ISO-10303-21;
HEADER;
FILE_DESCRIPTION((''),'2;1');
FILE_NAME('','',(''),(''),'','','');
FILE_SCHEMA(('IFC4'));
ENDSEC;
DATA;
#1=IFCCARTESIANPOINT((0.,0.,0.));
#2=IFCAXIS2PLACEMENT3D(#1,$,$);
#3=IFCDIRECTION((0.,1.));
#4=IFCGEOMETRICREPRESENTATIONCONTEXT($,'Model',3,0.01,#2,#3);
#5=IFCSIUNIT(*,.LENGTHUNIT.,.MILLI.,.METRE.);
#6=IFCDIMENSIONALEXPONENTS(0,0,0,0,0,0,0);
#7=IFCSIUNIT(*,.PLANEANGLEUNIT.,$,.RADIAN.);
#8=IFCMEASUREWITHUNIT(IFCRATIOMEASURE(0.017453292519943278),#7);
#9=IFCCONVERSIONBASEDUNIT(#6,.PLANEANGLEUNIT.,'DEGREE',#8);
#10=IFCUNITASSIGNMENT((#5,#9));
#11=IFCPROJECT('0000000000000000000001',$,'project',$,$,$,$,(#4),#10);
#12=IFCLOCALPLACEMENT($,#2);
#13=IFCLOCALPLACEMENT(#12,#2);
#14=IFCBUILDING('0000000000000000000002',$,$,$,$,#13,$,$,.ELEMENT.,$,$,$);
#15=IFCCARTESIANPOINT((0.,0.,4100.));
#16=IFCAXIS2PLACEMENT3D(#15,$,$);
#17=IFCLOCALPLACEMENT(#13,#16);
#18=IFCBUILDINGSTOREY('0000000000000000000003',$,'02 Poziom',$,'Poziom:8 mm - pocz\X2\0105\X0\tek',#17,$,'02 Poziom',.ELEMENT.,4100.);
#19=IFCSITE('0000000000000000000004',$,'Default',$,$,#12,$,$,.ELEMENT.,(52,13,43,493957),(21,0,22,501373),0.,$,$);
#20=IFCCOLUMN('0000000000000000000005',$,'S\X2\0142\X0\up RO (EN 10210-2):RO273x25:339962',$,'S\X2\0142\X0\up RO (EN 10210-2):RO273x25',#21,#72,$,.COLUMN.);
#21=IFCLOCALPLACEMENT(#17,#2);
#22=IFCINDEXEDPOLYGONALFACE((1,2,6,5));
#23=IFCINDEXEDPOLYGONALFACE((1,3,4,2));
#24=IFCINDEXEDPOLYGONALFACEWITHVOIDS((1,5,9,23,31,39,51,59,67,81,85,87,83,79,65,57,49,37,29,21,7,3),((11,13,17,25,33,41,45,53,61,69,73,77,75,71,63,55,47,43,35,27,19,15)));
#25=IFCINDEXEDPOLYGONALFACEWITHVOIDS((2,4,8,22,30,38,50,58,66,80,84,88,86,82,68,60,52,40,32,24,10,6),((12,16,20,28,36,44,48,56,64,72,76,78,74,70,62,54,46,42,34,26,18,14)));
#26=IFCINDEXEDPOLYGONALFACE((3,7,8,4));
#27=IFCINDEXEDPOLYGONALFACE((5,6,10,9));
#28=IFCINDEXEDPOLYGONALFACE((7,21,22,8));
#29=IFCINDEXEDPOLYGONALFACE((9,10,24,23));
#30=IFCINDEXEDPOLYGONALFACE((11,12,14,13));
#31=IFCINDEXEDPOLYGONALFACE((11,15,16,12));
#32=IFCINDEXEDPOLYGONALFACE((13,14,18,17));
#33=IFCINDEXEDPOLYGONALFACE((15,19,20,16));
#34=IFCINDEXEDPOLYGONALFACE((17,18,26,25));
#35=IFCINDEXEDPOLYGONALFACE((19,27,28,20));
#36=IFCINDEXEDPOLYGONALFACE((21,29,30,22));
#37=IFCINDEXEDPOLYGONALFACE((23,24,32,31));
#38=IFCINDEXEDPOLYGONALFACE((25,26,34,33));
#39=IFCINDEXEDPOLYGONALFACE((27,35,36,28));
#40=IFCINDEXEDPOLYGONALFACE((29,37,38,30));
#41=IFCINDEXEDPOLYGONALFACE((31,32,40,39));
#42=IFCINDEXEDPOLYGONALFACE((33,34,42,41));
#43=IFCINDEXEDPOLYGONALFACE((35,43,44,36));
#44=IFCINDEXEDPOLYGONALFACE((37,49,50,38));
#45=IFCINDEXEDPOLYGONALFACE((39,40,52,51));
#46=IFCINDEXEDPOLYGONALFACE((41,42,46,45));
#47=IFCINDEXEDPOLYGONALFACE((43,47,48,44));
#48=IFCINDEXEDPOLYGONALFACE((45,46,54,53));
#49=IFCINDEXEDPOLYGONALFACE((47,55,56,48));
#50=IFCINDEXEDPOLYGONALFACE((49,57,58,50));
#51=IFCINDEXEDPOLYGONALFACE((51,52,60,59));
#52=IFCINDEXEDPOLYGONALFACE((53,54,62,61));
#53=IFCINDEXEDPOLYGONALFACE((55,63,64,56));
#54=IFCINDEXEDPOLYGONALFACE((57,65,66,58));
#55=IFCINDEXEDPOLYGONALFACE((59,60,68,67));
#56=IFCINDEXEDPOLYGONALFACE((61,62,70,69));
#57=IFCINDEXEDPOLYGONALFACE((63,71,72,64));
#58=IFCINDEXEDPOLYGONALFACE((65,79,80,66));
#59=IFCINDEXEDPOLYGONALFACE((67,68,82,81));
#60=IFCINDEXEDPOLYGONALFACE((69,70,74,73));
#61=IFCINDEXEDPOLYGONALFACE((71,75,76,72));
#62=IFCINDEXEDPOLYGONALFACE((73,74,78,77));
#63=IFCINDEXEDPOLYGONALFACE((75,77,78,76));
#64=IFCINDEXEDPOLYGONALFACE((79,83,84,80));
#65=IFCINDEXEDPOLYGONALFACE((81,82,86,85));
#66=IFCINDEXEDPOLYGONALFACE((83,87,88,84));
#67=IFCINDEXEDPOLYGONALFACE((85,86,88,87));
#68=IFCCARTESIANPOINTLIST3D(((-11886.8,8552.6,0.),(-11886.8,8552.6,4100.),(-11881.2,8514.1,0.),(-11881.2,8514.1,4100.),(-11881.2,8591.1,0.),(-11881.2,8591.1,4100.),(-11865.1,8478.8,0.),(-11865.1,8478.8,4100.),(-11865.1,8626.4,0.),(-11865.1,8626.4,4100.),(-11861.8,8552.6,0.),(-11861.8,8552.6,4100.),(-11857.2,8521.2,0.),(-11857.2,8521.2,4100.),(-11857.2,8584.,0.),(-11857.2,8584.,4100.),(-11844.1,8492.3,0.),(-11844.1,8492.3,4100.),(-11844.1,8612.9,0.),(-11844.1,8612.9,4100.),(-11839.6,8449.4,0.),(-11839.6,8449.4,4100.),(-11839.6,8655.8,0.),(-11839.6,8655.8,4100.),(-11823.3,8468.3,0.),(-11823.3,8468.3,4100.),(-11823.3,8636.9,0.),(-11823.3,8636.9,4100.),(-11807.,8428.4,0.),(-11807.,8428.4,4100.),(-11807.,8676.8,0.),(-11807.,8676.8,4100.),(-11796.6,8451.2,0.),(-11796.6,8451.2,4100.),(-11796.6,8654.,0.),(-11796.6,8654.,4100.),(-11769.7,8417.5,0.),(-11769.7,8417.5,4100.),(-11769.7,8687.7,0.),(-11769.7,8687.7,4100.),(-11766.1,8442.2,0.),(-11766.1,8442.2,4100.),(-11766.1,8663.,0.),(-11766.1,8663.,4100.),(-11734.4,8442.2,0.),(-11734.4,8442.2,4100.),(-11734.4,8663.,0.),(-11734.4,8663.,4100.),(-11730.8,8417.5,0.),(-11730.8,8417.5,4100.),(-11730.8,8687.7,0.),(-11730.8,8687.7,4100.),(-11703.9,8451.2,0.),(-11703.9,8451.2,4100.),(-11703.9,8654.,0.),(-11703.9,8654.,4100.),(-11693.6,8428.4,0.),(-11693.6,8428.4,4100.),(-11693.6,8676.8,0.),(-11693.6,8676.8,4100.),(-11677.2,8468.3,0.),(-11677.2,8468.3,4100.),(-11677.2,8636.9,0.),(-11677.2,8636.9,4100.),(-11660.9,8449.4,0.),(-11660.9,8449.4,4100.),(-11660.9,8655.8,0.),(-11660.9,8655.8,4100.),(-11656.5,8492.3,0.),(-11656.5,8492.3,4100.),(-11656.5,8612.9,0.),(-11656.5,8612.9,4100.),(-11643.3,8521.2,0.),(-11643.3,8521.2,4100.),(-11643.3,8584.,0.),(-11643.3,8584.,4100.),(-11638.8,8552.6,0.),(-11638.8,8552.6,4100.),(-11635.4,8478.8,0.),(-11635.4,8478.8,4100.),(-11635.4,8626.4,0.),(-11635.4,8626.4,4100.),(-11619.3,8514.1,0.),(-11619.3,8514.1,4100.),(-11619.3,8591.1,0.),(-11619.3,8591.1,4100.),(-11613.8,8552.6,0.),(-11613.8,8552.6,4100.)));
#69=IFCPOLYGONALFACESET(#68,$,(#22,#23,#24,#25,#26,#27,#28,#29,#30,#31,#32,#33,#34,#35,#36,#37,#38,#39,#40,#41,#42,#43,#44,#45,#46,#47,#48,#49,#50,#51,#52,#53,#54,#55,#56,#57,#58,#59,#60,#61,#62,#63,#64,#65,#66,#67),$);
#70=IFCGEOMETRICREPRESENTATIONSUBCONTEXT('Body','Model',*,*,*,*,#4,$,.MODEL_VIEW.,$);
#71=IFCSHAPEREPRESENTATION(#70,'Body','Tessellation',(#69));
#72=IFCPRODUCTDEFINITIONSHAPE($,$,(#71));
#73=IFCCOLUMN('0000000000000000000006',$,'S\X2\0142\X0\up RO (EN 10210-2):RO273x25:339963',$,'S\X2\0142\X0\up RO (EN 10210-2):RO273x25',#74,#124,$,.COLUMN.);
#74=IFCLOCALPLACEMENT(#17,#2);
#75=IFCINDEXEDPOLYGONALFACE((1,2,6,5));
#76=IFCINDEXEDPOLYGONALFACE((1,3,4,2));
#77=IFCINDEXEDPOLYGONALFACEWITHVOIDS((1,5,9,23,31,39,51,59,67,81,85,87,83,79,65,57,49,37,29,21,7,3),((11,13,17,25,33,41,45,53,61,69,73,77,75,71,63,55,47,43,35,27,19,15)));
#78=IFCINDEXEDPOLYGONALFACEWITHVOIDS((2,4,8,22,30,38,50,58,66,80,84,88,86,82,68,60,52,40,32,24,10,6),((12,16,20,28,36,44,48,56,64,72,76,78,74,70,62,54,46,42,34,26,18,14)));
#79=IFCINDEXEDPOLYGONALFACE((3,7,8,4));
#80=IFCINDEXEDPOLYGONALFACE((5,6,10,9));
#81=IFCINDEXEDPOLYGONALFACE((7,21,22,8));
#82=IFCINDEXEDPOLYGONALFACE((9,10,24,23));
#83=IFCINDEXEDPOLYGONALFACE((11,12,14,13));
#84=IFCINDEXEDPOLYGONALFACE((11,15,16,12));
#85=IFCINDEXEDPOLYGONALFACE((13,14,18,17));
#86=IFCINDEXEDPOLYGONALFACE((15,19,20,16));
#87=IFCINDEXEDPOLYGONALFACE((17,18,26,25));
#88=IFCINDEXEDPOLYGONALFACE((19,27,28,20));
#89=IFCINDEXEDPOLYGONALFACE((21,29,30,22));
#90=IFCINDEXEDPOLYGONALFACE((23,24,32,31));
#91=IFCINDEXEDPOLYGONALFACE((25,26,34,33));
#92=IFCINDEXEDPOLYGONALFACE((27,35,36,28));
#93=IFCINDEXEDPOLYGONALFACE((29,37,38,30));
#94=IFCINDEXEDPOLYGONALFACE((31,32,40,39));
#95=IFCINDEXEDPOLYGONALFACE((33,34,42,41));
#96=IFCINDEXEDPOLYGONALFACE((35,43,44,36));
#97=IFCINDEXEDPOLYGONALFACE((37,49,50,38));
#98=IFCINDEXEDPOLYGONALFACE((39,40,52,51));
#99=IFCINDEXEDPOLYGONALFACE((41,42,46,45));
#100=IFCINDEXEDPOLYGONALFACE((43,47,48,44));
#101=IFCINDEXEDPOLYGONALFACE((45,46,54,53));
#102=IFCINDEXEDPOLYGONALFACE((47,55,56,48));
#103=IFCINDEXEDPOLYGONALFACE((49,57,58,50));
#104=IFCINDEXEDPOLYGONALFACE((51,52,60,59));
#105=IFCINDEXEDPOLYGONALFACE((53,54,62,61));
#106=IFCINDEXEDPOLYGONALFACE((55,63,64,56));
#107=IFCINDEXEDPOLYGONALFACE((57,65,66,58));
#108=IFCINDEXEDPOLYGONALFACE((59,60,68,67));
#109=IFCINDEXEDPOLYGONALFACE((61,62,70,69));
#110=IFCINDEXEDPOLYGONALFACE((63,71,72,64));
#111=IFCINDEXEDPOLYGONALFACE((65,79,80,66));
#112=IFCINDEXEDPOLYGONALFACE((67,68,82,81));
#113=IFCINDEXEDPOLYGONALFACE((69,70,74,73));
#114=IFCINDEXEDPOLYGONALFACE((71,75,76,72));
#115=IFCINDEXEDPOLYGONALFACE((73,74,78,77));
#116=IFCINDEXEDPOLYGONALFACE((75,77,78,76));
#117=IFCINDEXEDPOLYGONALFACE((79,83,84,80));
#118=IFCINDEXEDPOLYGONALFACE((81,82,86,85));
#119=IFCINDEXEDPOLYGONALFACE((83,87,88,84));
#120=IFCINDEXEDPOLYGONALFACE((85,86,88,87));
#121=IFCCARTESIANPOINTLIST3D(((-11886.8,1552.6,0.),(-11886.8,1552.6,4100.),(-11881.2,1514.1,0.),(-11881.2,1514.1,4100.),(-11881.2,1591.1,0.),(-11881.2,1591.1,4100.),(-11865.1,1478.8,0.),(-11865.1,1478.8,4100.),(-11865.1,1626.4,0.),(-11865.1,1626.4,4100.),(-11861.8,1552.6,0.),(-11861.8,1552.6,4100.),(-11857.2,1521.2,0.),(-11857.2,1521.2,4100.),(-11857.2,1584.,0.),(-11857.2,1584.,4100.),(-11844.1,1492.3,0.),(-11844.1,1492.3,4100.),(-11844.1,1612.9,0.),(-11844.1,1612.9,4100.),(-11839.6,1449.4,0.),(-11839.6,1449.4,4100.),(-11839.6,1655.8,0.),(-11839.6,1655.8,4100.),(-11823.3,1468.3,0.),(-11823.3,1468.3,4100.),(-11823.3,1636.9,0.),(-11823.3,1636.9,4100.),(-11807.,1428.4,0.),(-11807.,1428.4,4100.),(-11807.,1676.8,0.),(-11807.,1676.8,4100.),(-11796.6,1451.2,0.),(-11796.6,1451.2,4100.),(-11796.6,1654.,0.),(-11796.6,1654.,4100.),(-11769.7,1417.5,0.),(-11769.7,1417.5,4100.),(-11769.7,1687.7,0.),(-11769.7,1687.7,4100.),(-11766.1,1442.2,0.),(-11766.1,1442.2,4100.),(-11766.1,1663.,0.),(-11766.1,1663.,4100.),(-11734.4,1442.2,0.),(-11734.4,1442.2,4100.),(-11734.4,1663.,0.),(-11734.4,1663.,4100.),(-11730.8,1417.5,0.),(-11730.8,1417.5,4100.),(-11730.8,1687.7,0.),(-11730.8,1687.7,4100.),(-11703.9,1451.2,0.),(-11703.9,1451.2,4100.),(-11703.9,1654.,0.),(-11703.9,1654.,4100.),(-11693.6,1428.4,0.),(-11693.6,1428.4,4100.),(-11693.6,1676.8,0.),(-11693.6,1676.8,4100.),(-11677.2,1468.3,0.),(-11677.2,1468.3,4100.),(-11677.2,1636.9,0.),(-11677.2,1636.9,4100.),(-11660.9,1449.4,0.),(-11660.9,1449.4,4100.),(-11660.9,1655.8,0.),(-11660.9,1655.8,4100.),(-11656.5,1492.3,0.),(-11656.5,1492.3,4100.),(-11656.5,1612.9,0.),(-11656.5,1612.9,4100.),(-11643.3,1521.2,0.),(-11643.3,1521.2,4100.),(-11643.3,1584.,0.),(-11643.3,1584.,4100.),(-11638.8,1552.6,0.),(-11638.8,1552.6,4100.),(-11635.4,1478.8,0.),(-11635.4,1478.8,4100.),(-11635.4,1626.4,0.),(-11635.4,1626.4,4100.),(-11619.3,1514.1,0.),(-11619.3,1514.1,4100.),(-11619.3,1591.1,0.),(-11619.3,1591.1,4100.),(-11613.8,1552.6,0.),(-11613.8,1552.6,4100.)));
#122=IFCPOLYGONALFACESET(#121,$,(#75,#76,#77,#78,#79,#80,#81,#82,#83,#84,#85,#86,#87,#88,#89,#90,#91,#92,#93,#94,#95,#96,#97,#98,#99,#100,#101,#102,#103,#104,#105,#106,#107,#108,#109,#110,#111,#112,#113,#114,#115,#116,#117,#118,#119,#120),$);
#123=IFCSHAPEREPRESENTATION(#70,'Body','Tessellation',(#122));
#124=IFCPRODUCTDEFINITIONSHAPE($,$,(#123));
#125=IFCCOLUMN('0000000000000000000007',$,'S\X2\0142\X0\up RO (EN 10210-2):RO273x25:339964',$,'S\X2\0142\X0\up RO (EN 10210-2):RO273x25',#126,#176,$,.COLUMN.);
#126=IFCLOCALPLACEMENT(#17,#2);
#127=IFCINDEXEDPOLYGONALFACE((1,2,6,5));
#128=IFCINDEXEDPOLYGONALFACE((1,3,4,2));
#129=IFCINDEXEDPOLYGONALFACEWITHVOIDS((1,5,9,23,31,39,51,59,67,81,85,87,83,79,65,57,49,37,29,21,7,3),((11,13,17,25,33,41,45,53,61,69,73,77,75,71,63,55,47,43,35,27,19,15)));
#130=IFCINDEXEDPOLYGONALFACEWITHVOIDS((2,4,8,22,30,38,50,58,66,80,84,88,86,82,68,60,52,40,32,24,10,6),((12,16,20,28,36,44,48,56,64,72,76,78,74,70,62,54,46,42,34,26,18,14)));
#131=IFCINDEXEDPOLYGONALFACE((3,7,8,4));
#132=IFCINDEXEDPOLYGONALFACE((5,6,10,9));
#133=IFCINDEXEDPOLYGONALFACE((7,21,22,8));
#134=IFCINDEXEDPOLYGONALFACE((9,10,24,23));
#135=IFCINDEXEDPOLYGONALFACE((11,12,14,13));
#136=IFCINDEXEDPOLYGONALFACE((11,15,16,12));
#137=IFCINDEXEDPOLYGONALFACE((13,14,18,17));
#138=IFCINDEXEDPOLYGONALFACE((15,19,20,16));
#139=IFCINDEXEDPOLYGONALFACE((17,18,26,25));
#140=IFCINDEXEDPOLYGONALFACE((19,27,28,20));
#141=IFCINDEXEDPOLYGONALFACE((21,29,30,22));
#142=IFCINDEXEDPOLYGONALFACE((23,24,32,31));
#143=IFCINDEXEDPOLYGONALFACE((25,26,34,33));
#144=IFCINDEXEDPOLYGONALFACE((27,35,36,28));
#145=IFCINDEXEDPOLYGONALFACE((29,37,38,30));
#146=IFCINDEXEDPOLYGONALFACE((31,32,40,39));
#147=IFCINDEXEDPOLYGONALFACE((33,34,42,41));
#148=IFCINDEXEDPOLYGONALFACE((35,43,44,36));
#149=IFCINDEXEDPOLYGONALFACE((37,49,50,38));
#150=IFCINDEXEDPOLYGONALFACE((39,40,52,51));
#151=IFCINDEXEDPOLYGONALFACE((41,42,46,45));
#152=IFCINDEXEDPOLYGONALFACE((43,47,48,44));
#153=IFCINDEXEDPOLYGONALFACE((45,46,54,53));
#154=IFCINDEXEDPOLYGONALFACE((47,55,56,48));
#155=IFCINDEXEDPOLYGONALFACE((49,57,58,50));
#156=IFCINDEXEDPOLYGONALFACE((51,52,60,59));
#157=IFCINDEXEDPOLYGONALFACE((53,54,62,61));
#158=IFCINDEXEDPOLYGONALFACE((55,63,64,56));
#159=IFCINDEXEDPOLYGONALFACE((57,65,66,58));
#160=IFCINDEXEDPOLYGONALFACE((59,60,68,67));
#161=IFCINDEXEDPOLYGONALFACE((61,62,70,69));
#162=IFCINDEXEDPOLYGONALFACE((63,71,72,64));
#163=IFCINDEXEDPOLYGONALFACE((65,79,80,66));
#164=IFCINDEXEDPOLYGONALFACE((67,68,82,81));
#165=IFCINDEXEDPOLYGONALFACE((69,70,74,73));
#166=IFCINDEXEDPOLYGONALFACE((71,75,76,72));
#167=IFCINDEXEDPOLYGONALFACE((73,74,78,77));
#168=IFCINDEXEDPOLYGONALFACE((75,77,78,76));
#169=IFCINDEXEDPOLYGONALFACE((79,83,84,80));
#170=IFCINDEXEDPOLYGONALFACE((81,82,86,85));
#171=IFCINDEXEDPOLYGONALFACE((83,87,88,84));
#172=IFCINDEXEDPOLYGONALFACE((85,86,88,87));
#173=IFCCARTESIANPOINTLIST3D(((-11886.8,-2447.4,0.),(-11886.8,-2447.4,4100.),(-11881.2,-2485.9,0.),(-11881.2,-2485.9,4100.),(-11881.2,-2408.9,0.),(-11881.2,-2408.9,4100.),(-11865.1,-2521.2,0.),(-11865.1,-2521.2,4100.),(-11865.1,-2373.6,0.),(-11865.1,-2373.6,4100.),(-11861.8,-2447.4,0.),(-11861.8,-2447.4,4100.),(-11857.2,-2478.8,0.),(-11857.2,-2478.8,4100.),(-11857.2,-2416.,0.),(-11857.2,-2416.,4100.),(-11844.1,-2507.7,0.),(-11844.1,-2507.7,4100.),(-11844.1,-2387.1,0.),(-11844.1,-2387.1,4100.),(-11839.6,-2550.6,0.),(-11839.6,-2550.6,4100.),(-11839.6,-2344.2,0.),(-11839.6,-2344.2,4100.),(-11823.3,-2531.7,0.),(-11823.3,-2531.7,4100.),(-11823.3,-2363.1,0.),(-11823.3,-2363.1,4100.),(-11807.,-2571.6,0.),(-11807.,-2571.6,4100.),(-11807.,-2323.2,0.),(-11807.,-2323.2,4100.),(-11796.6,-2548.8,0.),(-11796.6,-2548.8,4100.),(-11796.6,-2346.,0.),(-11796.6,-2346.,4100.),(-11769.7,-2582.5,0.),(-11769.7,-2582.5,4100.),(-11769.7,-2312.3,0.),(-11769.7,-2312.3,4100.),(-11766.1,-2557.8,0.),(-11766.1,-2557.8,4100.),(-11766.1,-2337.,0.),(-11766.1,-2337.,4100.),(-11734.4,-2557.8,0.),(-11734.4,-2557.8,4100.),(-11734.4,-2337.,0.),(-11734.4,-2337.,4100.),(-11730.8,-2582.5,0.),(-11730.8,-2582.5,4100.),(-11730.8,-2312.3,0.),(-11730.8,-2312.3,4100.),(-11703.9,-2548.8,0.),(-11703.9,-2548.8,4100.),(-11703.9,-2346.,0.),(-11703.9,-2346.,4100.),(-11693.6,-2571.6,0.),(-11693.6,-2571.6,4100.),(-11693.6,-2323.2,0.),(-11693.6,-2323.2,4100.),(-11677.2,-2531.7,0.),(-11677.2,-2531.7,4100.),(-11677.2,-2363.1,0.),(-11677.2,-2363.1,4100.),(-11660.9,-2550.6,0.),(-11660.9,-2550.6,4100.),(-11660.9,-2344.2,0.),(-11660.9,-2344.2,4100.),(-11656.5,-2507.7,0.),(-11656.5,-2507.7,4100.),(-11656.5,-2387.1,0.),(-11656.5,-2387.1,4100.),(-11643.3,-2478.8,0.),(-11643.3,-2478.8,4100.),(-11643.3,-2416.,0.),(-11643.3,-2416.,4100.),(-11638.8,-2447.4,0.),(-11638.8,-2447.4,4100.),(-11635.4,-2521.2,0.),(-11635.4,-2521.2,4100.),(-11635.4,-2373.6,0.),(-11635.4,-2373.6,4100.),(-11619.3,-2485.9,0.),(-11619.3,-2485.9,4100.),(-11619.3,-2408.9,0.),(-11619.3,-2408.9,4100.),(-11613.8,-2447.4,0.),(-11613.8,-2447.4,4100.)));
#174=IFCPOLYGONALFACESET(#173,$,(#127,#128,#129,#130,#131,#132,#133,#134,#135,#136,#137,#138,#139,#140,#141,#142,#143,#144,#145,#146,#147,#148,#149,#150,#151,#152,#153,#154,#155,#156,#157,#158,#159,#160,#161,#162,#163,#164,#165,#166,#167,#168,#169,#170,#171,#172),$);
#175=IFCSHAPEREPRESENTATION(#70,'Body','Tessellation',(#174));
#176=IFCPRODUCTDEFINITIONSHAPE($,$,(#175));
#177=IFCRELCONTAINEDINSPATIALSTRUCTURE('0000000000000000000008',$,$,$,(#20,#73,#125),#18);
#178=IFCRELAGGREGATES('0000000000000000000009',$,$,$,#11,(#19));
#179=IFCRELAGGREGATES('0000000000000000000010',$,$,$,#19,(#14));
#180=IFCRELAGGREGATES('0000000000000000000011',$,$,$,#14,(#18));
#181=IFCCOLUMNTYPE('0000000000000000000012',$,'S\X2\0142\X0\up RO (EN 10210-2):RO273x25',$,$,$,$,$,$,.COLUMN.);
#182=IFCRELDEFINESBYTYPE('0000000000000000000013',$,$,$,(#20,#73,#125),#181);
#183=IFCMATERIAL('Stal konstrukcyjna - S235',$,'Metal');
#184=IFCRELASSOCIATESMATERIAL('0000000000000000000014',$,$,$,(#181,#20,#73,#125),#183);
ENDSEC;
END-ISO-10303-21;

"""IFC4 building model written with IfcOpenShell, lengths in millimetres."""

from ifc_helpers import new_model, entity, si_unit, converted_unit, direction, frame, origin, place, context, subcontext, project, spatial, arc, indexed_curve, outline, extrude, source, transform, mapped, material, type_object, type_shapes, element, save


model = new_model("IFC4")

# Units and contexts
model_context = context("Model", 3, precision=0.01, world=origin(), true_north=direction((0.0, 1.0)))
body_context = subcontext(model_context, "Body", "Model", "MODEL_VIEW")
ifc_project = project(units=[si_unit("LENGTHUNIT", "METRE", prefix="MILLI"), converted_unit("PLANEANGLEUNIT", "DEGREE", entity("IfcRatioMeasure", 0.017453292519943278), si_unit("PLANEANGLEUNIT", "RADIAN"), dimensions=[0, 0, 0, 0, 0, 0, 0])], contexts=[model_context])

# Site, building, storey
site_placement = place(None, origin())
site = spatial("IfcSite", under=ifc_project, at=site_placement, Name="Default", CompositionType="ELEMENT", RefLatitude=(52, 13, 43, 493957), RefLongitude=(21, 0, 22, 501373), RefElevation=0.0)
building_placement = place(site_placement, origin())
building = spatial("IfcBuilding", under=site, at=building_placement, CompositionType="ELEMENT")
storey_placement = place(building_placement, frame((0.0, 0.0, 4100.0)))
storey = spatial("IfcBuildingStorey", under=building, at=storey_placement, Name="02 Poziom", ObjectType="Poziom:8 mm - początek", LongName="02 Poziom", CompositionType="ELEMENT", Elevation=4100.0)

# Columns
ifc_material_1 = material(Name="Stal konstrukcyjna - S235", Category="Metal")
column_type = type_object("IfcColumnType", Name="Słup RO (EN 10210-2):RO273x25", PredefinedType="COLUMN", material=ifc_material_1)
shared_shape_1 = source(origin(), body_context, "Body", "SweptSolid", [
    extrude(outline(indexed_curve([(-136.5, 0.0), (0.0, -136.5), (136.5, 0.0), (0.0, 136.5)], segments=[arc(1, 2, 3), arc(3, 4, 1)], self_intersect=False), holes=[indexed_curve([(-111.5, 0.0), (0.0, 111.5), (111.5, 0.0), (0.0, -111.5)], segments=[arc(1, 2, 3), arc(3, 4, 1)], self_intersect=False)]), frame((0.0, 0.0, 4100.0)), (0.0, 0.0, 1.0), 4100.0),
])
type_shapes(column_type, [shared_shape_1])
for number, where, name in (
    (1, (-11750.3, 8552.6, -4100.0), "Słup RO (EN 10210-2):RO273x25:339962"),
    (2, (-11750.3, 1552.6, -4100.0), "Słup RO (EN 10210-2):RO273x25:339963"),
    (3, (-11750.3, -2447.4, -4100.0), "Słup RO (EN 10210-2):RO273x25:339964"),
):
    element("IfcColumn", number, at=place(storey_placement, frame(where)), inside=storey, type_object=column_type, material=ifc_material_1, Name=name, ObjectType="Słup RO (EN 10210-2):RO273x25", PredefinedType="COLUMN", context=body_context, shape_type="MappedRepresentation", body=[
        mapped(shared_shape_1, transform((0.0, 0.0, 0.0), scale=1.0)),
    ])

save(model, "model.ifc")
